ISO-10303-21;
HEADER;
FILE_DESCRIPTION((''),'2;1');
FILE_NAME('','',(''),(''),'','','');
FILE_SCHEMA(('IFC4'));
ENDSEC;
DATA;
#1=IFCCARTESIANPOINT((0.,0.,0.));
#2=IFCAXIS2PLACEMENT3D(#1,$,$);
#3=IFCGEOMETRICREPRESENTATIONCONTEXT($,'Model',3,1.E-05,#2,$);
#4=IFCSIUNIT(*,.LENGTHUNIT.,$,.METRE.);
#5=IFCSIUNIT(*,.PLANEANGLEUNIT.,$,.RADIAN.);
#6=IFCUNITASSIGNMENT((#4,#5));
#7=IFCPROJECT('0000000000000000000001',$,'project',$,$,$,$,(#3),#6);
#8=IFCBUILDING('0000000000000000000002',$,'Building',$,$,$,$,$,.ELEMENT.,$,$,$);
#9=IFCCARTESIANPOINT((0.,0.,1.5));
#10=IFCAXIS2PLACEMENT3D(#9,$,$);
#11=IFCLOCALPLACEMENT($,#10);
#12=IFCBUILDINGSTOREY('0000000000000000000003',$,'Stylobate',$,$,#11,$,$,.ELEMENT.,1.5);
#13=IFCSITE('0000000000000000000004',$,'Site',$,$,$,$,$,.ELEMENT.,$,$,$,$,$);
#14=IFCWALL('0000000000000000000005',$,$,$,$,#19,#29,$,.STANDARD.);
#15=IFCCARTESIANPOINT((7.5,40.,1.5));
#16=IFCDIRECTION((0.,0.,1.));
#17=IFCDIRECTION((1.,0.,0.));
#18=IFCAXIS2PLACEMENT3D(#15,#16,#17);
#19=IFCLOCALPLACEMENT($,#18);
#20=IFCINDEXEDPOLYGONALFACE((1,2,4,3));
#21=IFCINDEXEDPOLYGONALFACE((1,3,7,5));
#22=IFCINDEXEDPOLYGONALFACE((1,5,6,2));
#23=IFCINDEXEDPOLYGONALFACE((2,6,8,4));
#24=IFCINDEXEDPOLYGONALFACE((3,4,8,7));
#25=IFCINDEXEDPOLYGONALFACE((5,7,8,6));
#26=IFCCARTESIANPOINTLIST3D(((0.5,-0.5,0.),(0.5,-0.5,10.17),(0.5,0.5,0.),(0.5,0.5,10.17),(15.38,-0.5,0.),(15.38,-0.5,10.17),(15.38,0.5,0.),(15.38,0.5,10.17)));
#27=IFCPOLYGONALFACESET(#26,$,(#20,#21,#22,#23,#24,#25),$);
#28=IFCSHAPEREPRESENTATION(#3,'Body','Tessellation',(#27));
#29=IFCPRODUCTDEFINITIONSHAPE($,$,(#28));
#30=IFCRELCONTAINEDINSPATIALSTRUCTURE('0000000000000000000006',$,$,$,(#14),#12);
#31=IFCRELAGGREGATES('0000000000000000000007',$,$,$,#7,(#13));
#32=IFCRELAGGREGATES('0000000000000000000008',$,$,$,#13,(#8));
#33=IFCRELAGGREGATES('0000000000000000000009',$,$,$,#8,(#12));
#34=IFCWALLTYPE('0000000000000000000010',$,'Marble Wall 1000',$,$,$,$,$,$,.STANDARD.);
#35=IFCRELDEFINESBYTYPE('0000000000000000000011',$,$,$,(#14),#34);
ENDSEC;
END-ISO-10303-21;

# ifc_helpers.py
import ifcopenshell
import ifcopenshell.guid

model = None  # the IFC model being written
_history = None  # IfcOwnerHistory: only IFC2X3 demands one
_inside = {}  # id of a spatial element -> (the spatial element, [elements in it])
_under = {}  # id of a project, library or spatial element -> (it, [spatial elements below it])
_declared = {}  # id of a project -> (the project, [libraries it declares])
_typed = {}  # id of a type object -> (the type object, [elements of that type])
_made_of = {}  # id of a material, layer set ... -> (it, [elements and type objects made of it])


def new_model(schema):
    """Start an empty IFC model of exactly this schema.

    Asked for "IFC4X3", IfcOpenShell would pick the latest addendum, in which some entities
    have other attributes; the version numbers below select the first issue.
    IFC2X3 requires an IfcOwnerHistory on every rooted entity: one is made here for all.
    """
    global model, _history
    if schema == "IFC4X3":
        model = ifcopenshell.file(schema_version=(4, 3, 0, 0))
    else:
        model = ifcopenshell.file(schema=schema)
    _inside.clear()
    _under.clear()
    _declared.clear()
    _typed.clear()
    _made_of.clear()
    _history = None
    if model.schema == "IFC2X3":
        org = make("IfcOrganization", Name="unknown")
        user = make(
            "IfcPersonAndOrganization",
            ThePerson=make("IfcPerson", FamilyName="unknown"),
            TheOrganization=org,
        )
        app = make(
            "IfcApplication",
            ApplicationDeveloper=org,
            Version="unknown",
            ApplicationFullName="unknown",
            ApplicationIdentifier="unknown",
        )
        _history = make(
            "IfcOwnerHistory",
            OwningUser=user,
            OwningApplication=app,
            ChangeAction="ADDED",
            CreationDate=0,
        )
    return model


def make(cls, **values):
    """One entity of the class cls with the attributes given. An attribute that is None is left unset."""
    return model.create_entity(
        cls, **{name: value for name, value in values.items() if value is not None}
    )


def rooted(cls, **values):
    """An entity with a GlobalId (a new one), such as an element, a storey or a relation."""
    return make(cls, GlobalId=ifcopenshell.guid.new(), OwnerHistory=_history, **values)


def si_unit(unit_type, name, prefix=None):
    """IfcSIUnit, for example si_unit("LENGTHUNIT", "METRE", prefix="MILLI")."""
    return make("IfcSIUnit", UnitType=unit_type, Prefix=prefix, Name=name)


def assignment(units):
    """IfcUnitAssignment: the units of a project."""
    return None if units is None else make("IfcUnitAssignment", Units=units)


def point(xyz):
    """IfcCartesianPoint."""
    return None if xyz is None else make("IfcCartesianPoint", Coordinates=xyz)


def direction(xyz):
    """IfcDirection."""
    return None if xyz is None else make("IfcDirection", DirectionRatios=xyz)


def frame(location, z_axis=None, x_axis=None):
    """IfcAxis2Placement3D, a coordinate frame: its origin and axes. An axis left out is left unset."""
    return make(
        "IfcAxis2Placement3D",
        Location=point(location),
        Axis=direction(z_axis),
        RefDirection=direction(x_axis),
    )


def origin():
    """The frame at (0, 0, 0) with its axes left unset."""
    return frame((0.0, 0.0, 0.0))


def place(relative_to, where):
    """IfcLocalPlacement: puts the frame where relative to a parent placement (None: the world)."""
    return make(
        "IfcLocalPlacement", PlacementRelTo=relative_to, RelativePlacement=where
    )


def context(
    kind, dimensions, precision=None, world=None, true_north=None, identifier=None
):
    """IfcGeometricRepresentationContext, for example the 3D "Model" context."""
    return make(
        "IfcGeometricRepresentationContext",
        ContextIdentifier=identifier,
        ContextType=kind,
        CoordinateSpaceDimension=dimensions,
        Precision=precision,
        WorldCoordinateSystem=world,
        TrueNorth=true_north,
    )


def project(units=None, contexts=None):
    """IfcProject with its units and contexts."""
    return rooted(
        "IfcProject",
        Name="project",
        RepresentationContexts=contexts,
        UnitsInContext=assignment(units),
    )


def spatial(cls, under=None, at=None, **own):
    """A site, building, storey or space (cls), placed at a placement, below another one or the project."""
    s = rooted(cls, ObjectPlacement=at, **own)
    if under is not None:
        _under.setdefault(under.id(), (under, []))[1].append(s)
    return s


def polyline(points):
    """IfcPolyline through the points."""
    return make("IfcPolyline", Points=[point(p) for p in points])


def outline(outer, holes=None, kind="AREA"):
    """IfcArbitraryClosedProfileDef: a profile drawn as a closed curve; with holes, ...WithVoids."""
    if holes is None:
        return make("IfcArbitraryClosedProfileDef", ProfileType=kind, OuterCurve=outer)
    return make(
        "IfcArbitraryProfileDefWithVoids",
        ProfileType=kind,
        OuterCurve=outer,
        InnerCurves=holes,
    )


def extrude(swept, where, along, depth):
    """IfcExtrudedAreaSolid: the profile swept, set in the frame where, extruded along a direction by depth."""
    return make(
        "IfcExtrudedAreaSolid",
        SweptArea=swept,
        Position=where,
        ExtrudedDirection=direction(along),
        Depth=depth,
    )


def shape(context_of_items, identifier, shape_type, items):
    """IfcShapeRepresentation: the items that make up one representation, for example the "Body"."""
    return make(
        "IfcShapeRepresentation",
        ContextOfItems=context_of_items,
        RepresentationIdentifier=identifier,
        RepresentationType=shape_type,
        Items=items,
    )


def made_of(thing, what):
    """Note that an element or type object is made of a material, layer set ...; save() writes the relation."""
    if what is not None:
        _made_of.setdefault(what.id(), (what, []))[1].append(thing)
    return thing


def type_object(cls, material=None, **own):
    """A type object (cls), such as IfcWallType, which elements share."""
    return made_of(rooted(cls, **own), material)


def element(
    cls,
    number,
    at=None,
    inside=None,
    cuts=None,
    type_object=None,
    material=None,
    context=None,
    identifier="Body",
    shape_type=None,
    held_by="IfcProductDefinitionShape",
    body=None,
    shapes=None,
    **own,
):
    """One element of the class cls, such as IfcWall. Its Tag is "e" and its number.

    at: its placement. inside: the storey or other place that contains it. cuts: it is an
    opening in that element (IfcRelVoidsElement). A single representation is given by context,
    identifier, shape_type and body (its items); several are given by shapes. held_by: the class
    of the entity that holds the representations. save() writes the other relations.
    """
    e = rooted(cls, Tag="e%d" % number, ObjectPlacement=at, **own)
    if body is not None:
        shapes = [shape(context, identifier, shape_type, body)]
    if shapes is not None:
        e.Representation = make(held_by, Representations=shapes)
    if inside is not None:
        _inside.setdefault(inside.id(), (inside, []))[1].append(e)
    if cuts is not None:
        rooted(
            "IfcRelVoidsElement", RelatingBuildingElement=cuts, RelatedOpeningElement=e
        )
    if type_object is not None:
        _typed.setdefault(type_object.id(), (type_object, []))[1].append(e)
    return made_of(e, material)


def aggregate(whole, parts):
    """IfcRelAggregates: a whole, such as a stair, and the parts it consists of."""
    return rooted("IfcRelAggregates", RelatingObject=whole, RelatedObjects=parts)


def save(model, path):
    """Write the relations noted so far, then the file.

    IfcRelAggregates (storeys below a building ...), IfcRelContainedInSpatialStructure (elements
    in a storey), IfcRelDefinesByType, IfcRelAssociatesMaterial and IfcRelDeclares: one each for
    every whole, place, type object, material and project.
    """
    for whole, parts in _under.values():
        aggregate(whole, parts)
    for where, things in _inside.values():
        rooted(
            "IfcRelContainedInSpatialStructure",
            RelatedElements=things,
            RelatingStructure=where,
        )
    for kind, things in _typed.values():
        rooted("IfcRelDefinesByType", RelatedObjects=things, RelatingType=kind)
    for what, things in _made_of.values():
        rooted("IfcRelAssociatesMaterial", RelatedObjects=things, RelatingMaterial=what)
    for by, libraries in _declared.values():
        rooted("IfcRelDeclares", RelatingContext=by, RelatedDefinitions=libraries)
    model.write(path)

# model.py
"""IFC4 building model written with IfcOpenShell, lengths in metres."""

from ifc_helpers import new_model, si_unit, frame, origin, place, context, project, spatial, polyline, outline, extrude, type_object, element, save


model = new_model("IFC4")

# Units and contexts
model_context = context("Model", 3, precision=1e-05, world=origin())
ifc_project = project(units=[si_unit("LENGTHUNIT", "METRE"), si_unit("PLANEANGLEUNIT", "RADIAN")], contexts=[model_context])

# Site, building, storey
site = spatial("IfcSite", under=ifc_project, Name="Site", CompositionType="ELEMENT")
building = spatial("IfcBuilding", under=site, Name="Building", CompositionType="ELEMENT")
storey_placement = place(None, frame((0.0, 0.0, 1.5)))
storey = spatial("IfcBuildingStorey", under=building, at=storey_placement, Name="Stylobate", CompositionType="ELEMENT", Elevation=1.5)

# Wall
wall_type = type_object("IfcWallType", Name="Marble Wall 1000", PredefinedType="STANDARD")
wall_placement = place(None, frame((7.5, 40.0, 1.5), z_axis=(0.0, 0.0, 1.0), x_axis=(1.0, 0.0, 0.0)))
element("IfcWall", 1, at=wall_placement, inside=storey, type_object=wall_type, PredefinedType="STANDARD", context=model_context, shape_type="SweptSolid", body=[
    extrude(outline(polyline([(0.5, -0.5), (15.38, -0.5), (15.38, 0.5), (0.5, 0.5), (0.5, -0.5)])), origin(), (0.0, 0.0, 1.0), 10.17),
])

save(model, "model.ifc")
